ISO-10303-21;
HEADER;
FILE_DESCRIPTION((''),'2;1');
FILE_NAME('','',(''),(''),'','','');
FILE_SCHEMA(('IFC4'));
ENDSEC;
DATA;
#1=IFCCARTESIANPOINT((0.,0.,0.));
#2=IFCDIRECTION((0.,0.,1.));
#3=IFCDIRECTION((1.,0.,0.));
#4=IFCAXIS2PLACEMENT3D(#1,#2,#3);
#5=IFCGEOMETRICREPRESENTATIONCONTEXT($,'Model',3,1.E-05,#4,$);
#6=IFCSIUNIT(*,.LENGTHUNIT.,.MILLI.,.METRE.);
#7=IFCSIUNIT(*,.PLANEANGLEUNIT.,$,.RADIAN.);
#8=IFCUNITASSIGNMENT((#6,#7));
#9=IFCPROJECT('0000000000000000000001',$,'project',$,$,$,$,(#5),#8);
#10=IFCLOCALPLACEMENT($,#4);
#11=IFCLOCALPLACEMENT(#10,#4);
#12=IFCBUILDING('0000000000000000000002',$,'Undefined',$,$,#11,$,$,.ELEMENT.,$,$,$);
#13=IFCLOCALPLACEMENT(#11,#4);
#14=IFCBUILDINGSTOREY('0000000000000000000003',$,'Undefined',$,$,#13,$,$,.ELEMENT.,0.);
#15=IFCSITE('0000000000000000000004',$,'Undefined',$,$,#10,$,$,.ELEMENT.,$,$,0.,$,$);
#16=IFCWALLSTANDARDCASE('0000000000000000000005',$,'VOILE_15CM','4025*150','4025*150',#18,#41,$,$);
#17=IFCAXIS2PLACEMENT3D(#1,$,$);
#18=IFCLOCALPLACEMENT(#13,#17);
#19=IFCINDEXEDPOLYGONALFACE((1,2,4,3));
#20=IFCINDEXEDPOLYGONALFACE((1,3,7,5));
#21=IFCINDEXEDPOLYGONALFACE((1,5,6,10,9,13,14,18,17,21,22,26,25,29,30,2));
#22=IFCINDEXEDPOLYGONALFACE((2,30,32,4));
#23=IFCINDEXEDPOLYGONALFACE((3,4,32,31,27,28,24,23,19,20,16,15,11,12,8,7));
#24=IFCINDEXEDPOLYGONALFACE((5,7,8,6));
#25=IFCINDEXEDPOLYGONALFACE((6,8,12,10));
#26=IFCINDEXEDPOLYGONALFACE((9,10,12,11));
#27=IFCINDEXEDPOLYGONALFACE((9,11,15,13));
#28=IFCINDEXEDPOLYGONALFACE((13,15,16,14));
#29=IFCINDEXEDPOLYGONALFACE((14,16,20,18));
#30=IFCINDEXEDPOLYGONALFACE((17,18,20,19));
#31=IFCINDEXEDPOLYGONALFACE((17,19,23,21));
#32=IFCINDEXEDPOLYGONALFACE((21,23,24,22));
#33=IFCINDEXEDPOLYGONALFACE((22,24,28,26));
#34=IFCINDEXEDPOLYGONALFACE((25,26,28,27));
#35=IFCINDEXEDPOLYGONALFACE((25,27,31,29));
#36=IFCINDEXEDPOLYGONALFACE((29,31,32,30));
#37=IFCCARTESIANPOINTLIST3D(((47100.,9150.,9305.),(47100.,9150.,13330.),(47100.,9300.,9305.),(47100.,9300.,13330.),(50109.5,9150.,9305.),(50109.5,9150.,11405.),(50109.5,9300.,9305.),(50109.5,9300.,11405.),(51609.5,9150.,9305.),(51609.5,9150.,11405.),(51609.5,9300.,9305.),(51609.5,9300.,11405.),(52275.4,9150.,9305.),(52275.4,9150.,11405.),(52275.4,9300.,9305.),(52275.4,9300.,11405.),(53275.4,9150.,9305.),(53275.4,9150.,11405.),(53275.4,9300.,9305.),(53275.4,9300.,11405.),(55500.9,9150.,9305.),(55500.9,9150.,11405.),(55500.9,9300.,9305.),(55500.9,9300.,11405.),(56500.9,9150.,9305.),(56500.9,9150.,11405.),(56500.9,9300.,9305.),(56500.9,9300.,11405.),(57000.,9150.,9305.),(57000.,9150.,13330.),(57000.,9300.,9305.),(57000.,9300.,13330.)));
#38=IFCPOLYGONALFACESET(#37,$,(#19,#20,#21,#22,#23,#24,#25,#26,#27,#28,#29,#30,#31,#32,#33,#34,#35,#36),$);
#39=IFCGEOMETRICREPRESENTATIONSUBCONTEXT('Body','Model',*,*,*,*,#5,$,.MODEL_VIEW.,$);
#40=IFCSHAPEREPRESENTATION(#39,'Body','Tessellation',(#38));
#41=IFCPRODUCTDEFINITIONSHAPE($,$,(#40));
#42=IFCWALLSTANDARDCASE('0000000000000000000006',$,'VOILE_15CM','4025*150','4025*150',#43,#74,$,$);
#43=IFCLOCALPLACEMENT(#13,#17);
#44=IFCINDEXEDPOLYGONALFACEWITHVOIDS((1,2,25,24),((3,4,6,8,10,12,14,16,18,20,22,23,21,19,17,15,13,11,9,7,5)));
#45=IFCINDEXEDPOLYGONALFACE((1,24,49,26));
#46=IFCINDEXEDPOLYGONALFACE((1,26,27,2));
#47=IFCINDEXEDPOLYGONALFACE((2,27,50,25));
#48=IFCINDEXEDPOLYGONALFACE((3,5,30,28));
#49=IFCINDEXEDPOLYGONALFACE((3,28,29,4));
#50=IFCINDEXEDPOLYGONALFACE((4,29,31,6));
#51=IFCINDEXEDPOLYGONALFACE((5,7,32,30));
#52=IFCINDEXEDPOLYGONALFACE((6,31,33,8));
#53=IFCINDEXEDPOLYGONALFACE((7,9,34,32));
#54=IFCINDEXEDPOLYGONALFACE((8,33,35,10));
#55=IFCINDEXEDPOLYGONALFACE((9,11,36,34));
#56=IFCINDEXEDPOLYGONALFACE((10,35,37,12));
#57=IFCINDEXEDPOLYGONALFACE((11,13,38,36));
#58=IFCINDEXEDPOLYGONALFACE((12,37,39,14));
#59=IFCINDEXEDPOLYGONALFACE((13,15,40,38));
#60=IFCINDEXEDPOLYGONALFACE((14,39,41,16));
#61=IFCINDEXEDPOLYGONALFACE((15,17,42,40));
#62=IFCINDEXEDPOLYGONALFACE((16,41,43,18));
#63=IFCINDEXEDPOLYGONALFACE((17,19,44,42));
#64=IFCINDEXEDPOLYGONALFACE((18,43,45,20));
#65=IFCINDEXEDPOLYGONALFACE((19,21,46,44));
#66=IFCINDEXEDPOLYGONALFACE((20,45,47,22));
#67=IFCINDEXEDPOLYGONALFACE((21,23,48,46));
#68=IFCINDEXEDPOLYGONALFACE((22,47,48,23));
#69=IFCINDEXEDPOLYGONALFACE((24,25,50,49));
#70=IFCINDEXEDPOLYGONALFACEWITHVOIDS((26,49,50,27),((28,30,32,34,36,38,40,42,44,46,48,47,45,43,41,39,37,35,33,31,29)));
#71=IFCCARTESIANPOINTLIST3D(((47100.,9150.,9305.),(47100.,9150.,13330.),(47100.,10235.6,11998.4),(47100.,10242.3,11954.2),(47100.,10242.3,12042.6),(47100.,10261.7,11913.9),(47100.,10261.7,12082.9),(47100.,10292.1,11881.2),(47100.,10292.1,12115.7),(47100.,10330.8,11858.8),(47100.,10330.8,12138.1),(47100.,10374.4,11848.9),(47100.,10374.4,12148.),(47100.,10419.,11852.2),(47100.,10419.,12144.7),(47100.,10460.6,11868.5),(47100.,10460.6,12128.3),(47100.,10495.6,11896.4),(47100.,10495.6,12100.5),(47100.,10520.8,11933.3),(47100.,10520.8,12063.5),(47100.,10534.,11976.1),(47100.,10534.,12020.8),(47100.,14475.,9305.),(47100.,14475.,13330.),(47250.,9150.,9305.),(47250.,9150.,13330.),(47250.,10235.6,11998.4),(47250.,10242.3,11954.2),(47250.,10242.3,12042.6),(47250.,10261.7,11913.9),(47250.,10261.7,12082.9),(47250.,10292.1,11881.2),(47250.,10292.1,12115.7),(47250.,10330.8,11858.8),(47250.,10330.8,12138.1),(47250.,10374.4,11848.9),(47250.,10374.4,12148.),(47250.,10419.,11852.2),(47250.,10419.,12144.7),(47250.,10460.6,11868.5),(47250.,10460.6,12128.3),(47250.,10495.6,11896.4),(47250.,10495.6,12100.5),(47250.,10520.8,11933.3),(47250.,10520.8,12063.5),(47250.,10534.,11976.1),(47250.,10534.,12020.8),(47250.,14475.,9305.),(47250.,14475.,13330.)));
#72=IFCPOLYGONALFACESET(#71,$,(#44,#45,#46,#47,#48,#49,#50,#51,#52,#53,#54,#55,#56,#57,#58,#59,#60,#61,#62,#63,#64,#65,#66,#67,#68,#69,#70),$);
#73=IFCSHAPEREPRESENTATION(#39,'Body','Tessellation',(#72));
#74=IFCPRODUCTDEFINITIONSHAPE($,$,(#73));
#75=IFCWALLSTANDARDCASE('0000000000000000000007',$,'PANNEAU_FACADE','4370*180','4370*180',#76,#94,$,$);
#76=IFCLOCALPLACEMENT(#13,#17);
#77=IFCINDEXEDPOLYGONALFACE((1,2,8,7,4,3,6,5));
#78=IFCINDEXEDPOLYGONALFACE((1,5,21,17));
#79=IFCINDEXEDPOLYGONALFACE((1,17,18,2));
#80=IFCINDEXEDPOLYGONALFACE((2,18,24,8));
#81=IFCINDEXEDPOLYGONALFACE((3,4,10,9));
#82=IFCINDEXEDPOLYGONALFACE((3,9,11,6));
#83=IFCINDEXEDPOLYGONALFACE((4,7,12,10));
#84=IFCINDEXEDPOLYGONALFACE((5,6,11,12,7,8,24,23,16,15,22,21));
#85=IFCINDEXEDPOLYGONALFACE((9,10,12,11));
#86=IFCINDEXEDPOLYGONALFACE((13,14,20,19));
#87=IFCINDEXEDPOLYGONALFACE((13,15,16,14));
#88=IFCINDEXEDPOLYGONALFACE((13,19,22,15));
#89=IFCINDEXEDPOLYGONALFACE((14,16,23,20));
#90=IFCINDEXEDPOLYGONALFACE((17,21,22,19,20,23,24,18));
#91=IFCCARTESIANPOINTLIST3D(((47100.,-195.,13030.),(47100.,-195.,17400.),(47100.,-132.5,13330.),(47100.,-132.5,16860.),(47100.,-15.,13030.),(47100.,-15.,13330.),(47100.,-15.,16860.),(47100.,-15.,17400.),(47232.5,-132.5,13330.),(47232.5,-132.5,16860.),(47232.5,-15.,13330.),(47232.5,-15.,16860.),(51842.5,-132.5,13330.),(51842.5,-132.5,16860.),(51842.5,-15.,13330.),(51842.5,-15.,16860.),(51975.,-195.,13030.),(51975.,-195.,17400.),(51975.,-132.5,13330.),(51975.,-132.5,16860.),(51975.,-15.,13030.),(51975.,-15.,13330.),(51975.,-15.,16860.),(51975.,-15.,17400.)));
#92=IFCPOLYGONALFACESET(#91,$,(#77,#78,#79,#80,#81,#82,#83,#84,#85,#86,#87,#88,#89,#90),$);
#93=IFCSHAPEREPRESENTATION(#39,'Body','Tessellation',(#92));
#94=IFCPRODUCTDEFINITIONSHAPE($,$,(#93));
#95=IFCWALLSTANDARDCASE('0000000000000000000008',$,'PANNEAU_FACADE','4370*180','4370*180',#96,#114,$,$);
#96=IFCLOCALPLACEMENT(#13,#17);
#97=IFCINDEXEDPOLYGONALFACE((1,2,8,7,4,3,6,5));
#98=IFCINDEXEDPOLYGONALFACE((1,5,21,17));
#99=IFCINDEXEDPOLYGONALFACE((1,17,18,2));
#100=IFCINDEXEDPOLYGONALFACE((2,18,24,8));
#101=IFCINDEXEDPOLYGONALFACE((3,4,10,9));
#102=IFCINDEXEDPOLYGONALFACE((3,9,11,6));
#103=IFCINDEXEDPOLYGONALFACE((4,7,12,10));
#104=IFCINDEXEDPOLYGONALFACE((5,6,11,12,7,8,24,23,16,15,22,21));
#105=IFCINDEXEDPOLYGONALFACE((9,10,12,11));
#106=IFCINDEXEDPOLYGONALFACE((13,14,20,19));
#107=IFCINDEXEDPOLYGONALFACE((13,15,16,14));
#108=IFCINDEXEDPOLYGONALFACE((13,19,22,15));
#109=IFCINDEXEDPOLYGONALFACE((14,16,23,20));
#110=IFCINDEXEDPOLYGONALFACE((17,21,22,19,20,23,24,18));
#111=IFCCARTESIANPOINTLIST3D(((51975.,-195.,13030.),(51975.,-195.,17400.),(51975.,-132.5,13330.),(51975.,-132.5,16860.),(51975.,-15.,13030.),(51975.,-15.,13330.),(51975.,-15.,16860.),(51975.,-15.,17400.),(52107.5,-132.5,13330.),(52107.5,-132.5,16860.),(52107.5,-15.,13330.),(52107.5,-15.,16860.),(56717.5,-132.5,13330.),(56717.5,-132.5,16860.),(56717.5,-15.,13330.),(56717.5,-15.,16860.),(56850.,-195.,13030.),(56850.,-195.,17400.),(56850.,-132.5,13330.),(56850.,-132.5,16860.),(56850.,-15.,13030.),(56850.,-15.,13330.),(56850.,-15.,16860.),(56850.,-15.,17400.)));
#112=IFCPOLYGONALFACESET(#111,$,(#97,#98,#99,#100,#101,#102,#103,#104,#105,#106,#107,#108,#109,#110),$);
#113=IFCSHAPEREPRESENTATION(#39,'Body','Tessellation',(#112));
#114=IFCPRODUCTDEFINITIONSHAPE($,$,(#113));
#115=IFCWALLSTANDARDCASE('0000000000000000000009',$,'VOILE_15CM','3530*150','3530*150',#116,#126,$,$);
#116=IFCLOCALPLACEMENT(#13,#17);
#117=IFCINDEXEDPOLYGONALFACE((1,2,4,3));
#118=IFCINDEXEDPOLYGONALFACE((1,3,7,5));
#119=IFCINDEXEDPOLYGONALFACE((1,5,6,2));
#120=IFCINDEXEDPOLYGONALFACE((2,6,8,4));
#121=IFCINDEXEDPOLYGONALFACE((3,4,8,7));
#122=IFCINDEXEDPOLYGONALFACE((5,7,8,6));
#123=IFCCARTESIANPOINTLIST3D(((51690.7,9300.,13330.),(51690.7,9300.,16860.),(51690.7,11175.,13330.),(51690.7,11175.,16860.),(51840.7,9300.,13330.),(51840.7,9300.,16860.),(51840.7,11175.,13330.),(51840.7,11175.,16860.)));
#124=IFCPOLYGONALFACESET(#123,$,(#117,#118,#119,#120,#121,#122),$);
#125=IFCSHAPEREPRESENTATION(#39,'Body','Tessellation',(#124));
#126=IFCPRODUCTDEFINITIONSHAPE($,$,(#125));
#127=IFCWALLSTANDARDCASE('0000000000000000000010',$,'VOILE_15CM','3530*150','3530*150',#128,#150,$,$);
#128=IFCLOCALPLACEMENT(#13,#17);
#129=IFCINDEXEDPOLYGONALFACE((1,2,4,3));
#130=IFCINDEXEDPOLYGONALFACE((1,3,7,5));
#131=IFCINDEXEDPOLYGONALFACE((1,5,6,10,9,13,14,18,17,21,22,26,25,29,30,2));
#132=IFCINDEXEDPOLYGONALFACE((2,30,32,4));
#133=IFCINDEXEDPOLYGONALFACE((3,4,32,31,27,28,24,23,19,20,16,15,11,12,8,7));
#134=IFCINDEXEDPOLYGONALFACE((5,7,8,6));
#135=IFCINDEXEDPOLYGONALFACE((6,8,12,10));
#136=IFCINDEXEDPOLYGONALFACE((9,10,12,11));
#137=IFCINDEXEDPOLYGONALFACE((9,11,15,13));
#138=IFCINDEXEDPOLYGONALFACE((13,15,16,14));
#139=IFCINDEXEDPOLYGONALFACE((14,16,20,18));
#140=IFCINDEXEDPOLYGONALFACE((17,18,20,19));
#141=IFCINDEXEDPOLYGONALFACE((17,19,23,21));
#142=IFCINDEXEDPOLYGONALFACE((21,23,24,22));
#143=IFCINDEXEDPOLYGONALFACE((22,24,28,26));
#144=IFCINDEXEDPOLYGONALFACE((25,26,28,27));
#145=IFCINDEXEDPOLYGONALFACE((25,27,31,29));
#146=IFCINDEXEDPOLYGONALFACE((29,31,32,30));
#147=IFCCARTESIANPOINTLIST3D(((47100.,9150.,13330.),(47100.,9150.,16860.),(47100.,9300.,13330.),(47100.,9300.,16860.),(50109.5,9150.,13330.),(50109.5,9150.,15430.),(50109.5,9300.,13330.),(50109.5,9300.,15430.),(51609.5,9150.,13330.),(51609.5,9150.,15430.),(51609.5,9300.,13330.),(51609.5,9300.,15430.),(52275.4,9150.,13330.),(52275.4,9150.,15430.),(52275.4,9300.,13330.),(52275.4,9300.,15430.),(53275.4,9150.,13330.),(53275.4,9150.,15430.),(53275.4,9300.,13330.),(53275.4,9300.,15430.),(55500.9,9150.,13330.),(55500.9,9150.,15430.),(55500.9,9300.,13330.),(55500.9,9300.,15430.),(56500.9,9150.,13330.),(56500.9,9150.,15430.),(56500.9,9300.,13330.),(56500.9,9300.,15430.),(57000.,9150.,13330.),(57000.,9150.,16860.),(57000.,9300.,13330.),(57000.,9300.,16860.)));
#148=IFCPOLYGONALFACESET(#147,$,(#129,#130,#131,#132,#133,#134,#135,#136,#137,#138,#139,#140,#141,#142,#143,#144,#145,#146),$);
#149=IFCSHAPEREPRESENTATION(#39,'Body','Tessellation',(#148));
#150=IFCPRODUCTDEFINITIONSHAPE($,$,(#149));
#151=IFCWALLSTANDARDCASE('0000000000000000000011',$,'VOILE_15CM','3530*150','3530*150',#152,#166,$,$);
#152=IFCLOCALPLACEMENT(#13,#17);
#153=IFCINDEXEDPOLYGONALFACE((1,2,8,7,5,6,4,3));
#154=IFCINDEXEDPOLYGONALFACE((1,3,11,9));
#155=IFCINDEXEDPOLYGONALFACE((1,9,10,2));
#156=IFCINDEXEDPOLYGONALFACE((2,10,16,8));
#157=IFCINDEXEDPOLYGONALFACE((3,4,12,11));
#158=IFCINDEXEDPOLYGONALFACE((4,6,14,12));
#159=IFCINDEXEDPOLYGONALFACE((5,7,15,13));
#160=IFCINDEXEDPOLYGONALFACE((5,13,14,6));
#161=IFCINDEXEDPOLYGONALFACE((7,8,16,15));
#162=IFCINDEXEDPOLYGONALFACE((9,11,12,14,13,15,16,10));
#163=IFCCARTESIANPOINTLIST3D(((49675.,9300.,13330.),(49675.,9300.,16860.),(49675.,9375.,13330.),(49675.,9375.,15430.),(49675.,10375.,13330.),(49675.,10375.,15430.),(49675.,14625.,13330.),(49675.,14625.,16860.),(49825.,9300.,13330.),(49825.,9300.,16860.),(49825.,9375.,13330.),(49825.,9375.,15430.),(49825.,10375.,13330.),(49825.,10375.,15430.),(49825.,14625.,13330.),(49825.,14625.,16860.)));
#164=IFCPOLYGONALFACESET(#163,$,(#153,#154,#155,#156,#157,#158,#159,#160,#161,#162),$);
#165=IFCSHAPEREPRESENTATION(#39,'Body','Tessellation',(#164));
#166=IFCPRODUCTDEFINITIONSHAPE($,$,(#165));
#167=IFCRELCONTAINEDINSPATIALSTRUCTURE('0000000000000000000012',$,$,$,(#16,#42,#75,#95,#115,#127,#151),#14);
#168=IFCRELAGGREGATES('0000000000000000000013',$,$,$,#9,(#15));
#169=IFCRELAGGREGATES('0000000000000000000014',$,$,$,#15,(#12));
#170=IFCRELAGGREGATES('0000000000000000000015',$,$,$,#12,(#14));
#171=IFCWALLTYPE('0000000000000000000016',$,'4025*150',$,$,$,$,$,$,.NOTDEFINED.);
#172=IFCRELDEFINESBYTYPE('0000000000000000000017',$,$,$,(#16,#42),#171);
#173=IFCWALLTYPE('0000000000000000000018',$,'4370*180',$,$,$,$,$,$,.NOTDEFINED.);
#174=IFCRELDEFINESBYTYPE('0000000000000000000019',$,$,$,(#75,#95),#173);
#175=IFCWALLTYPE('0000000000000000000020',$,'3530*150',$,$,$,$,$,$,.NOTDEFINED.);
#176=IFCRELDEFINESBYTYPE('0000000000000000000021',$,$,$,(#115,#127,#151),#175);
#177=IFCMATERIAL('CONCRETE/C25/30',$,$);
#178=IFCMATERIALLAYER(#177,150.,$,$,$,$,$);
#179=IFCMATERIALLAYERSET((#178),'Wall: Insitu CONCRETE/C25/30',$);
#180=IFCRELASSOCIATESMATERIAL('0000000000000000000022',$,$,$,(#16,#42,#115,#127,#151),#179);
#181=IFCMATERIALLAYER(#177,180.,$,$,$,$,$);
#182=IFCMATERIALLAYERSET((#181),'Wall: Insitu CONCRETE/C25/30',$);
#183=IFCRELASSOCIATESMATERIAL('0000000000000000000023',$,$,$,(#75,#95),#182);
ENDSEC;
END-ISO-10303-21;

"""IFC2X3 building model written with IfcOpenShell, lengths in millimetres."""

from ifc_helpers import new_model, si_unit, frame, frame_2d, origin_with_axes, origin_2d_with_axis, place, context, subcontext, project, spatial, polyline, rectangle, circle, outline, extrude, boolean, material, layer, layer_set, layer_usage, type_object, element, save


model = new_model("IFC2X3")

# Units and contexts
model_context = context("Model", 3, precision=1e-05, world=origin_with_axes())
body_context = subcontext(model_context, "Body", "Model", "MODEL_VIEW")
ifc_project = project(units=[si_unit("LENGTHUNIT", "METRE", prefix="MILLI"), si_unit("PLANEANGLEUNIT", "RADIAN")], contexts=[model_context])

# Site, building, storey
site_placement = place(None, origin_with_axes())
site = spatial("IfcSite", under=ifc_project, at=site_placement, Name="Undefined", CompositionType="ELEMENT", RefElevation=0.0)
building_placement = place(site_placement, origin_with_axes())
building = spatial("IfcBuilding", under=site, at=building_placement, Name="Undefined", CompositionType="ELEMENT")
storey_placement = place(building_placement, origin_with_axes())
storey = spatial("IfcBuildingStorey", under=building, at=storey_placement, Name="Undefined", CompositionType="ELEMENT", Elevation=0.0)

# Shared definitions
ifc_material_1 = material(Name="CONCRETE/C25/30")

# Walls
ifc_layer_1 = layer(ifc_material_1, 150.0)
ifc_layer_set_1 = layer_set([ifc_layer_1], Name="Wall: Insitu CONCRETE/C25/30")
wall_type_1 = type_object("IfcWallType", Name="4025*150", PredefinedType="NOTDEFINED")
ifc_layer_usage_1 = layer_usage(ifc_layer_set_1, "AXIS2", "POSITIVE", -75.0)
wall_1_placement = place(storey_placement, frame((47100.0, 9225.0, 9305.0), z_axis=(0.0, 0.0, 1.0), x_axis=(1.0, 0.0, 0.0)))
element("IfcWallStandardCase", 1, at=wall_1_placement, inside=storey, type_object=wall_type_1, material=ifc_layer_usage_1, Name="VOILE_15CM", Description="4025*150", ObjectType="4025*150", context=body_context, shape_type="CSG", body=[
    boolean("DIFFERENCE", boolean("DIFFERENCE", boolean("DIFFERENCE", extrude(rectangle(XDim=9900.0, YDim=150.0, at=frame_2d((0.0, 4950.0), x_axis=(0.0, -1.0))), frame((0.0, 0.0, 0.0), z_axis=(0.0, 0.0, 1.0), x_axis=(0.0, -1.0, 0.0)), (0.0, 0.0, 1.0), 4025.0), extrude(outline(polyline([(0.0, 0.0), (2100.0, 0.0), (2100.0, 1000.0), (0.0, 1000.0), (0.0, 0.0)])), frame((8400.9, 85.0, 2100.0), z_axis=(0.0, -1.0, 0.0), x_axis=(0.0, 0.0, -1.0)), (0.0, 0.0, 1.0), 170.0)), extrude(outline(polyline([(0.0, 0.0), (2100.0, 0.0), (2100.0, 1000.0), (0.0, 1000.0), (0.0, 0.0)])), frame((5175.4, 85.0, 2100.0), z_axis=(0.0, -1.0, 0.0), x_axis=(0.0, 0.0, -1.0)), (0.0, 0.0, 1.0), 170.0)), extrude(outline(polyline([(0.0, 0.0), (2100.0, 0.0), (2100.0, 1500.0), (0.0, 1500.0), (0.0, 0.0)])), frame((3009.5, 85.0, 2100.0), z_axis=(0.0, -1.0, 0.0), x_axis=(0.0, 0.0, -1.0)), (0.0, 0.0, 1.0), 170.0)),
])
ifc_layer_usage_2 = layer_usage(ifc_layer_set_1, "AXIS2", "POSITIVE", -75.0)
wall_2_placement = place(storey_placement, frame((47175.0, 9150.0, 9305.0), z_axis=(0.0, 0.0, 1.0), x_axis=(0.0, 1.0, 0.0)))
element("IfcWallStandardCase", 2, at=wall_2_placement, inside=storey, type_object=wall_type_1, material=ifc_layer_usage_2, Name="VOILE_15CM", Description="4025*150", ObjectType="4025*150", context=body_context, shape_type="CSG", body=[
    boolean("DIFFERENCE", extrude(rectangle(XDim=5325.0, YDim=150.0, at=frame_2d((0.0, 2662.5), x_axis=(0.0, -1.0))), frame((0.0, 0.0, 0.0), z_axis=(0.0, 0.0, 1.0), x_axis=(0.0, -1.0, 0.0)), (0.0, 0.0, 1.0), 4025.0), extrude(circle(Radius=150.0, at=origin_2d_with_axis()), frame((1235.6, -85.0, 2693.4), z_axis=(0.0, 1.0, 0.0), x_axis=(-1.0, 0.0, 0.0)), (0.0, 0.0, 1.0), 170.0)),
])
ifc_layer_2 = layer(ifc_material_1, 180.0)
ifc_layer_set_2 = layer_set([ifc_layer_2], Name="Wall: Insitu CONCRETE/C25/30")
ifc_layer_usage_3 = layer_usage(ifc_layer_set_2, "AXIS2", "POSITIVE", -90.0)
wall_type_2 = type_object("IfcWallType", Name="4370*180", PredefinedType="NOTDEFINED")
wall_3_placement = place(storey_placement, frame((51975.0, -105.0, 13030.0), z_axis=(0.0, 0.0, 1.0), x_axis=(-1.0, 0.0, 0.0)))
element("IfcWallStandardCase", 3, at=wall_3_placement, inside=storey, type_object=wall_type_2, material=ifc_layer_usage_3, Name="PANNEAU_FACADE", Description="4370*180", ObjectType="4370*180", context=body_context, shape_type="CSG", body=[
    boolean("DIFFERENCE", boolean("DIFFERENCE", extrude(rectangle(XDim=4875.0, YDim=180.0, at=frame_2d((0.0, 2437.5), x_axis=(0.0, -1.0))), frame((0.0, 0.0, 0.0), z_axis=(0.0, 0.0, 1.0), x_axis=(0.0, -1.0, 0.0)), (0.0, 0.0, 1.0), 4370.0), extrude(rectangle(XDim=265.0, YDim=265.0, at=origin_2d_with_axis()), frame((0.0, -105.0, 3830.0), z_axis=(0.0, 0.0, -1.0), x_axis=(1.0, 0.0, 0.0)), (0.0, 0.0, 1.0), 3530.0)), extrude(rectangle(XDim=265.0, YDim=265.0, at=origin_2d_with_axis()), frame((4875.0, -105.0, 3830.0), z_axis=(0.0, 0.0, -1.0), x_axis=(1.0, 0.0, 0.0)), (0.0, 0.0, 1.0), 3530.0)),
])
ifc_layer_usage_4 = layer_usage(ifc_layer_set_2, "AXIS2", "POSITIVE", -90.0)
wall_4_placement = place(storey_placement, frame((56850.0, -105.0, 13030.0), z_axis=(0.0, 0.0, 1.0), x_axis=(-1.0, 0.0, 0.0)))
element("IfcWallStandardCase", 4, at=wall_4_placement, inside=storey, type_object=wall_type_2, material=ifc_layer_usage_4, Name="PANNEAU_FACADE", Description="4370*180", ObjectType="4370*180", context=body_context, shape_type="CSG", body=[
    boolean("DIFFERENCE", boolean("DIFFERENCE", extrude(rectangle(XDim=4875.0, YDim=180.0, at=frame_2d((0.0, 2437.5), x_axis=(0.0, -1.0))), frame((0.0, 0.0, 0.0), z_axis=(0.0, 0.0, 1.0), x_axis=(0.0, -1.0, 0.0)), (0.0, 0.0, 1.0), 4370.0), extrude(rectangle(XDim=265.0, YDim=265.0, at=origin_2d_with_axis()), frame((0.0, -105.0, 3830.0), z_axis=(0.0, 0.0, -1.0), x_axis=(1.0, 0.0, 0.0)), (0.0, 0.0, 1.0), 3530.0)), extrude(rectangle(XDim=265.0, YDim=265.0, at=origin_2d_with_axis()), frame((4875.0, -105.0, 3830.0), z_axis=(0.0, 0.0, -1.0), x_axis=(1.0, 0.0, 0.0)), (0.0, 0.0, 1.0), 3530.0)),
])
ifc_layer_usage_5 = layer_usage(ifc_layer_set_1, "AXIS2", "POSITIVE", -75.0)
wall_type_3 = type_object("IfcWallType", Name="3530*150", PredefinedType="NOTDEFINED")
wall_5_placement = place(storey_placement, frame((51765.7, 9300.0, 13330.0), z_axis=(0.0, 0.0, 1.0), x_axis=(0.0, 1.0, 0.0)))
element("IfcWallStandardCase", 5, at=wall_5_placement, inside=storey, type_object=wall_type_3, material=ifc_layer_usage_5, Name="VOILE_15CM", Description="3530*150", ObjectType="3530*150", context=body_context, shape_type="SweptSolid", body=[
    extrude(rectangle(XDim=1875.0, YDim=150.0, at=frame_2d((0.0, 937.5), x_axis=(0.0, -1.0))), frame((0.0, 0.0, 0.0), z_axis=(0.0, 0.0, 1.0), x_axis=(0.0, -1.0, 0.0)), (0.0, 0.0, 1.0), 3530.0),
])
ifc_layer_usage_6 = layer_usage(ifc_layer_set_1, "AXIS2", "POSITIVE", -75.0)
wall_6_placement = place(storey_placement, frame((47100.0, 9225.0, 13330.0), z_axis=(0.0, 0.0, 1.0), x_axis=(1.0, 0.0, 0.0)))
element("IfcWallStandardCase", 6, at=wall_6_placement, inside=storey, type_object=wall_type_3, material=ifc_layer_usage_6, Name="VOILE_15CM", Description="3530*150", ObjectType="3530*150", context=body_context, shape_type="CSG", body=[
    boolean("DIFFERENCE", boolean("DIFFERENCE", boolean("DIFFERENCE", extrude(rectangle(XDim=9900.0, YDim=150.0, at=frame_2d((0.0, 4950.0), x_axis=(0.0, -1.0))), frame((0.0, 0.0, 0.0), z_axis=(0.0, 0.0, 1.0), x_axis=(0.0, -1.0, 0.0)), (0.0, 0.0, 1.0), 3530.0), extrude(outline(polyline([(0.0, 0.0), (2100.0, 0.0), (2100.0, 1000.0), (0.0, 1000.0), (0.0, 0.0)])), frame((8400.9, 85.0, 2100.0), z_axis=(0.0, -1.0, 0.0), x_axis=(0.0, 0.0, -1.0)), (0.0, 0.0, 1.0), 170.0)), extrude(outline(polyline([(0.0, 0.0), (2100.0, 0.0), (2100.0, 1000.0), (0.0, 1000.0), (0.0, 0.0)])), frame((5175.4, 85.0, 2100.0), z_axis=(0.0, -1.0, 0.0), x_axis=(0.0, 0.0, -1.0)), (0.0, 0.0, 1.0), 170.0)), extrude(outline(polyline([(0.0, 0.0), (2100.0, 0.0), (2100.0, 1500.0), (0.0, 1500.0), (0.0, 0.0)])), frame((3009.5, 85.0, 2100.0), z_axis=(0.0, -1.0, 0.0), x_axis=(0.0, 0.0, -1.0)), (0.0, 0.0, 1.0), 170.0)),
])
ifc_layer_usage_7 = layer_usage(ifc_layer_set_1, "AXIS2", "POSITIVE", -75.0)
wall_7_placement = place(storey_placement, frame((49750.0, 9300.0, 13330.0), z_axis=(0.0, 0.0, 1.0), x_axis=(0.0, 1.0, 0.0)))
element("IfcWallStandardCase", 7, at=wall_7_placement, inside=storey, type_object=wall_type_3, material=ifc_layer_usage_7, Name="VOILE_15CM", Description="3530*150", ObjectType="3530*150", context=body_context, shape_type="CSG", body=[
    boolean("DIFFERENCE", extrude(rectangle(XDim=5325.0, YDim=150.0, at=frame_2d((0.0, 2662.5), x_axis=(0.0, -1.0))), frame((0.0, 0.0, 0.0), z_axis=(0.0, 0.0, 1.0), x_axis=(0.0, -1.0, 0.0)), (0.0, 0.0, 1.0), 3530.0), extrude(outline(polyline([(0.0, 0.0), (2100.0, 0.0), (2100.0, 1000.0), (0.0, 1000.0), (0.0, 0.0)])), frame((75.0, 85.0, 2100.0), z_axis=(0.0, -1.0, 0.0), x_axis=(0.0, 0.0, -1.0)), (0.0, 0.0, 1.0), 170.0)),
])

save(model, "model.ifc")
